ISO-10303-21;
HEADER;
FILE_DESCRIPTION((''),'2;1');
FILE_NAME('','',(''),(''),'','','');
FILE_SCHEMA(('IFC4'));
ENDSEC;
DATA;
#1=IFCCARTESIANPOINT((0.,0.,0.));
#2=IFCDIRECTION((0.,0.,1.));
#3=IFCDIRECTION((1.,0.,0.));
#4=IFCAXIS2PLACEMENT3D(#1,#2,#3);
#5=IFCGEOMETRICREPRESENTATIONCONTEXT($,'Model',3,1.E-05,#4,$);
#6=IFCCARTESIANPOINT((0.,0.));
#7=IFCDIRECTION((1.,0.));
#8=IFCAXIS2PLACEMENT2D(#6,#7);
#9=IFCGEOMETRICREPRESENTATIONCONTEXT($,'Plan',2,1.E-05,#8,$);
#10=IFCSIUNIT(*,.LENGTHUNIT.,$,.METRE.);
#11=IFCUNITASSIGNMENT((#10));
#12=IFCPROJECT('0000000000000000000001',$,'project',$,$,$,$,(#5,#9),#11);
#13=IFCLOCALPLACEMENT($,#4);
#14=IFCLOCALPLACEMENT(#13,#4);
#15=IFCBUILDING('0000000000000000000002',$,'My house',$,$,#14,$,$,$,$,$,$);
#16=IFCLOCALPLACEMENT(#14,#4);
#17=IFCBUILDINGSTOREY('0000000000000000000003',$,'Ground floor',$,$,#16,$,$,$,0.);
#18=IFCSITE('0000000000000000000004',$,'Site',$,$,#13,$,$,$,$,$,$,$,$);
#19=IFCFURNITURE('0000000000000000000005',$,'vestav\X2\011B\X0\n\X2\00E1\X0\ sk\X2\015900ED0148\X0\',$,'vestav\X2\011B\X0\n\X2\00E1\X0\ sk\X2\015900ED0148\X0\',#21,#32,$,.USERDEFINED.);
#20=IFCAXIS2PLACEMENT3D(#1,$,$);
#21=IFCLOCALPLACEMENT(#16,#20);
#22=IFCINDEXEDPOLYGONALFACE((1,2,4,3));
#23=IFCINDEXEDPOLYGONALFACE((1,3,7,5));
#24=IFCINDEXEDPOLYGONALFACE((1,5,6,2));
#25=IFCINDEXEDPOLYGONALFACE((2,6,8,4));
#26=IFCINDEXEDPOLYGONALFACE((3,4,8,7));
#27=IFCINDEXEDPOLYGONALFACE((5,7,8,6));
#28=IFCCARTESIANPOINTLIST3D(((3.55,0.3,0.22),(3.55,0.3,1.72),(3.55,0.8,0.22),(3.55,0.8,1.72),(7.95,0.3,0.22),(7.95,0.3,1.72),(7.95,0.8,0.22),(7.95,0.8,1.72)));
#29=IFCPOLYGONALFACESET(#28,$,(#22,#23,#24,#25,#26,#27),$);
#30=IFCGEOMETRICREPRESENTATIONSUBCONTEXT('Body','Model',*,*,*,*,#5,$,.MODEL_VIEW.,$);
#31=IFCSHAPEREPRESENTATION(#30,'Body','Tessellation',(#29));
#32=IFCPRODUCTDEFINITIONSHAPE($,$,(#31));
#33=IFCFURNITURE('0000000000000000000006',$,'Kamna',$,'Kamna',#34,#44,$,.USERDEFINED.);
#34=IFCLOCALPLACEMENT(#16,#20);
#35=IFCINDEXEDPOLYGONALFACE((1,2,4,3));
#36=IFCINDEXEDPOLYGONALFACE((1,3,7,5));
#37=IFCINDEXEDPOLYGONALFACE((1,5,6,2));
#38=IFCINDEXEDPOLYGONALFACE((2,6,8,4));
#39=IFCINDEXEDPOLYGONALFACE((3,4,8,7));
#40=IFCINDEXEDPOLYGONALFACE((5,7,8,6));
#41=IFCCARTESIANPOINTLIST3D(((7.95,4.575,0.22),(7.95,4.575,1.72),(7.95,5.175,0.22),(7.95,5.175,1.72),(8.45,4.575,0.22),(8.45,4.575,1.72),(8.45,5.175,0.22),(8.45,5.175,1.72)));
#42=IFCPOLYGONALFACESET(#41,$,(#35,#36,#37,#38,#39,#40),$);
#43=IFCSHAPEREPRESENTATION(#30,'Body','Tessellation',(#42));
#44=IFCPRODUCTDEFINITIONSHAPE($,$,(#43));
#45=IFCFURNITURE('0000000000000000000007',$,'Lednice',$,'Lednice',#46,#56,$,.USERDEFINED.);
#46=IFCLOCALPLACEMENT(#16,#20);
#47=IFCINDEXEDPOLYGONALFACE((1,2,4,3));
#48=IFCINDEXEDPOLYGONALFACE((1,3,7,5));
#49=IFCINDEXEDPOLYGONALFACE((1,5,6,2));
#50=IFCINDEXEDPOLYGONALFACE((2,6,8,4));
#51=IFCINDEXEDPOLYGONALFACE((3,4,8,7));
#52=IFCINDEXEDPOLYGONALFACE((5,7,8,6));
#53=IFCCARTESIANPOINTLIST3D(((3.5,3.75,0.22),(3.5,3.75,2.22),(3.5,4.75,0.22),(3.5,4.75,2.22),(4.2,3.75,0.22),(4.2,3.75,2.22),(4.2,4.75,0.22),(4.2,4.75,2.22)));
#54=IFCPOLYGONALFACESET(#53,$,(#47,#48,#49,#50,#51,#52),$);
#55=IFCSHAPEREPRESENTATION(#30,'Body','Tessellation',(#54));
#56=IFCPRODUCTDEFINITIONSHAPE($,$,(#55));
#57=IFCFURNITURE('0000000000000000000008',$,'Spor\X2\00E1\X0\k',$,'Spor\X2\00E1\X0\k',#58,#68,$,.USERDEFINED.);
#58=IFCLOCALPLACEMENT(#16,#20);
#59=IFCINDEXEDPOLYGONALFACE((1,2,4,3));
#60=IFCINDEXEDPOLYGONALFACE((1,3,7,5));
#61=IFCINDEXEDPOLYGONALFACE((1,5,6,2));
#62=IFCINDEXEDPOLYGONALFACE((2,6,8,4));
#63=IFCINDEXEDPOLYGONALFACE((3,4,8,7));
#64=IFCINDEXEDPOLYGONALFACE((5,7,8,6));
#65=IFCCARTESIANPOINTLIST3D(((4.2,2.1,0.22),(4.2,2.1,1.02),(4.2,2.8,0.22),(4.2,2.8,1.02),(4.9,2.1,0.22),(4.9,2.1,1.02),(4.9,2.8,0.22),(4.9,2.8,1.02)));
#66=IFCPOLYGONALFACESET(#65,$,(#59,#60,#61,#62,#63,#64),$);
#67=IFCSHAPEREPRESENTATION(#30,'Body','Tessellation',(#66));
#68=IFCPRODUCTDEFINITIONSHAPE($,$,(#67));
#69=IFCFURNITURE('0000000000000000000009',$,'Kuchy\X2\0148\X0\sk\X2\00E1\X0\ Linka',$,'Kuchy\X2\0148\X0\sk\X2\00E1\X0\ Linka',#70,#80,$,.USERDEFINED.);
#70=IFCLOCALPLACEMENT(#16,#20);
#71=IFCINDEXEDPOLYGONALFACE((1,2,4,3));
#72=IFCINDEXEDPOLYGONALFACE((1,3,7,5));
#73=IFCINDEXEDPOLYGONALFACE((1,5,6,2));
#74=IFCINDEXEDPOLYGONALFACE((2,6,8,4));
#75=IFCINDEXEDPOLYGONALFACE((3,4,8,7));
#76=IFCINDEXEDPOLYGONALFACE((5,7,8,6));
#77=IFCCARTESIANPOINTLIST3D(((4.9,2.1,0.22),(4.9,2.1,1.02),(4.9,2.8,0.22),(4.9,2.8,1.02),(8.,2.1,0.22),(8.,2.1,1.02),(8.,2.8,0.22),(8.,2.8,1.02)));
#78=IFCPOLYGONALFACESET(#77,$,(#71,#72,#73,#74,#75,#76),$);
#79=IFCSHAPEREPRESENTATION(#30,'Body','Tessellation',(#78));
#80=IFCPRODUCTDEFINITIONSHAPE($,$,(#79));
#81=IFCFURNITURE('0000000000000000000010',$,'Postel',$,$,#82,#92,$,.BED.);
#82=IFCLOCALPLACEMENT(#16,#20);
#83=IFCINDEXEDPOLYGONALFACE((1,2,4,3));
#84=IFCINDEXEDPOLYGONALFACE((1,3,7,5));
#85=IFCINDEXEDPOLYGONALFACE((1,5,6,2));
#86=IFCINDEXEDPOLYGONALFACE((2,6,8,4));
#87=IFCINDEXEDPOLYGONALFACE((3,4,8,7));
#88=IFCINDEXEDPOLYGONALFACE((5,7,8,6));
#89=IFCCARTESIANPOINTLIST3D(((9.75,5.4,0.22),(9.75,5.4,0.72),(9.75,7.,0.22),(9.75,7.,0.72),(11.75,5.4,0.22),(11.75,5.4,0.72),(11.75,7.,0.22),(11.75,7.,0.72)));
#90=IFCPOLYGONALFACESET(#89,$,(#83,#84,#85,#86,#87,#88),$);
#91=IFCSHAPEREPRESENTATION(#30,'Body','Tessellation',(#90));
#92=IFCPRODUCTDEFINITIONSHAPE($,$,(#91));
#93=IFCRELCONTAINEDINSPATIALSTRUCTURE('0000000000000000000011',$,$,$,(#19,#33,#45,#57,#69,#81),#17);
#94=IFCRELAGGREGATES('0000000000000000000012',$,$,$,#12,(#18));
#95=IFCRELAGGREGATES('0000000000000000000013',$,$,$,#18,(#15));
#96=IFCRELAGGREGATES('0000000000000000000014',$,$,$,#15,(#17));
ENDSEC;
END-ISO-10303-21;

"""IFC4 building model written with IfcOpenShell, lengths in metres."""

from ifc_helpers import new_model, entity, si_unit, frame, origin_with_axes, origin_2d_with_axis, place, context, subcontext, project, spatial, indexed_curve, outline, extrude, shape, element, save


model = new_model("IFC4")

# Units and contexts
model_context = context("Model", 3, precision=1e-05, world=origin_with_axes())
plan_context = context("Plan", 2, precision=1e-05, world=origin_2d_with_axis())
body_context_1 = subcontext(model_context, "Body", "Model", "MODEL_VIEW")
body_context_2 = subcontext(plan_context, "Body", "Plan", "PLAN_VIEW")
ifc_project = project(units=[si_unit("LENGTHUNIT", "METRE")], contexts=[model_context, plan_context])

# Site, building, storey
site_placement = place(None, origin_with_axes())
site = spatial("IfcSite", under=ifc_project, at=site_placement, Name="Site")
building_placement = place(site_placement, origin_with_axes())
building = spatial("IfcBuilding", under=site, at=building_placement, Name="My house")
storey_placement = place(building_placement, origin_with_axes())
storey = spatial("IfcBuildingStorey", under=building, at=storey_placement, Name="Ground floor", Elevation=0.0)

# Furniture
furniture_1_placement = place(storey_placement, frame((5.75, 0.55, 0.22), z_axis=(0.0, 0.0, 1.0), x_axis=(1.0, 0.0, 0.0)))
element("IfcFurniture", 1, at=furniture_1_placement, inside=storey, Name="vestavěná skříň", ObjectType="vestavěná skříň", PredefinedType="USERDEFINED", shapes=[
    shape(body_context_1, "Body", "SweptSolid", [extrude(outline(indexed_curve([(-2.2, -0.25), (2.2, -0.25), (2.2, 0.25), (-2.2, 0.25)])), None, (0.0, 0.0, 1.0), 1.5)]),
    shape(body_context_2, "Body", "Curve2D", [entity("IfcIndexedPolyCurve", entity("IfcCartesianPointList2D", [[-2.2, -0.25], [2.2, -0.25], [2.2, 0.25], [-2.2, 0.25], [-2.2, -0.25]]), None, False)]),
])
furniture_2_placement = place(storey_placement, frame((8.2, 4.875, 0.22), z_axis=(0.0, 0.0, 1.0), x_axis=(1.0, 0.0, 0.0)))
element("IfcFurniture", 2, at=furniture_2_placement, inside=storey, Name="Kamna", ObjectType="Kamna", PredefinedType="USERDEFINED", shapes=[
    shape(body_context_1, "Body", "SweptSolid", [extrude(outline(indexed_curve([(-0.25, -0.3), (0.25, -0.3), (0.25, 0.3), (-0.25, 0.3)])), None, (0.0, 0.0, 1.0), 1.5)]),
    shape(body_context_2, "Body", "Curve2D", [entity("IfcIndexedPolyCurve", entity("IfcCartesianPointList2D", [[-0.25, -0.3], [0.25, -0.3], [0.25, 0.3], [-0.25, 0.3], [-0.25, -0.3]]), None, False)]),
])
furniture_3_placement = place(storey_placement, frame((3.85, 4.25, 0.22), z_axis=(0.0, 0.0, 1.0), x_axis=(1.0, 0.0, 0.0)))
element("IfcFurniture", 3, at=furniture_3_placement, inside=storey, Name="Lednice", ObjectType="Lednice", PredefinedType="USERDEFINED", shapes=[
    shape(body_context_1, "Body", "SweptSolid", [extrude(outline(indexed_curve([(-0.35, -0.5), (0.35, -0.5), (0.35, 0.5), (-0.35, 0.5)])), None, (0.0, 0.0, 1.0), 2.0)]),
    shape(body_context_2, "Body", "Curve2D", [entity("IfcIndexedPolyCurve", entity("IfcCartesianPointList2D", [[-0.35, -0.5], [0.35, -0.5], [0.35, 0.5], [-0.35, 0.5], [-0.35, -0.5]]), None, False)]),
])
furniture_4_placement = place(storey_placement, frame((4.55, 2.45, 0.22), z_axis=(0.0, 0.0, 1.0), x_axis=(1.0, 0.0, 0.0)))
element("IfcFurniture", 4, at=furniture_4_placement, inside=storey, Name="Sporák", ObjectType="Sporák", PredefinedType="USERDEFINED", shapes=[
    shape(body_context_1, "Body", "SweptSolid", [extrude(outline(indexed_curve([(-0.35, -0.35), (0.35, -0.35), (0.35, 0.35), (-0.35, 0.35)])), None, (0.0, 0.0, 1.0), 0.8)]),
    shape(body_context_2, "Body", "Curve2D", [entity("IfcIndexedPolyCurve", entity("IfcCartesianPointList2D", [[-0.35, -0.35], [0.35, -0.35], [0.35, 0.35], [-0.35, 0.35], [-0.35, -0.35]]), None, False)]),
])
furniture_5_placement = place(storey_placement, frame((6.45, 2.45, 0.22), z_axis=(0.0, 0.0, 1.0), x_axis=(1.0, 0.0, 0.0)))
element("IfcFurniture", 5, at=furniture_5_placement, inside=storey, Name="Kuchyňská Linka", ObjectType="Kuchyňská Linka", PredefinedType="USERDEFINED", shapes=[
    shape(body_context_1, "Body", "SweptSolid", [extrude(outline(indexed_curve([(-1.55, -0.35), (1.55, -0.35), (1.55, 0.35), (-1.55, 0.35)])), None, (0.0, 0.0, 1.0), 0.8)]),
    shape(body_context_2, "Body", "Curve2D", [entity("IfcIndexedPolyCurve", entity("IfcCartesianPointList2D", [[-1.55, -0.35], [1.55, -0.35], [1.55, 0.35], [-1.55, 0.35], [-1.55, -0.35]]), None, False)]),
])
furniture_6_placement = place(storey_placement, frame((10.75, 6.2, 0.22), z_axis=(0.0, 0.0, 1.0), x_axis=(0.0, -1.0, 0.0)))
element("IfcFurniture", 6, at=furniture_6_placement, inside=storey, Name="Postel", PredefinedType="BED", shapes=[
    shape(body_context_1, "Body", "SweptSolid", [extrude(outline(indexed_curve([(-0.8, -1.0), (0.8, -1.0), (0.8, 1.0), (-0.8, 1.0)])), None, (0.0, 0.0, 1.0), 0.5)]),
    shape(body_context_2, "Body", "Curve2D", [entity("IfcIndexedPolyCurve", entity("IfcCartesianPointList2D", [[-0.8, -1.0], [0.8, -1.0], [0.8, 1.0], [-0.8, 1.0], [-0.8, -1.0]]), None, False)]),
])

save(model, "model.ifc")
